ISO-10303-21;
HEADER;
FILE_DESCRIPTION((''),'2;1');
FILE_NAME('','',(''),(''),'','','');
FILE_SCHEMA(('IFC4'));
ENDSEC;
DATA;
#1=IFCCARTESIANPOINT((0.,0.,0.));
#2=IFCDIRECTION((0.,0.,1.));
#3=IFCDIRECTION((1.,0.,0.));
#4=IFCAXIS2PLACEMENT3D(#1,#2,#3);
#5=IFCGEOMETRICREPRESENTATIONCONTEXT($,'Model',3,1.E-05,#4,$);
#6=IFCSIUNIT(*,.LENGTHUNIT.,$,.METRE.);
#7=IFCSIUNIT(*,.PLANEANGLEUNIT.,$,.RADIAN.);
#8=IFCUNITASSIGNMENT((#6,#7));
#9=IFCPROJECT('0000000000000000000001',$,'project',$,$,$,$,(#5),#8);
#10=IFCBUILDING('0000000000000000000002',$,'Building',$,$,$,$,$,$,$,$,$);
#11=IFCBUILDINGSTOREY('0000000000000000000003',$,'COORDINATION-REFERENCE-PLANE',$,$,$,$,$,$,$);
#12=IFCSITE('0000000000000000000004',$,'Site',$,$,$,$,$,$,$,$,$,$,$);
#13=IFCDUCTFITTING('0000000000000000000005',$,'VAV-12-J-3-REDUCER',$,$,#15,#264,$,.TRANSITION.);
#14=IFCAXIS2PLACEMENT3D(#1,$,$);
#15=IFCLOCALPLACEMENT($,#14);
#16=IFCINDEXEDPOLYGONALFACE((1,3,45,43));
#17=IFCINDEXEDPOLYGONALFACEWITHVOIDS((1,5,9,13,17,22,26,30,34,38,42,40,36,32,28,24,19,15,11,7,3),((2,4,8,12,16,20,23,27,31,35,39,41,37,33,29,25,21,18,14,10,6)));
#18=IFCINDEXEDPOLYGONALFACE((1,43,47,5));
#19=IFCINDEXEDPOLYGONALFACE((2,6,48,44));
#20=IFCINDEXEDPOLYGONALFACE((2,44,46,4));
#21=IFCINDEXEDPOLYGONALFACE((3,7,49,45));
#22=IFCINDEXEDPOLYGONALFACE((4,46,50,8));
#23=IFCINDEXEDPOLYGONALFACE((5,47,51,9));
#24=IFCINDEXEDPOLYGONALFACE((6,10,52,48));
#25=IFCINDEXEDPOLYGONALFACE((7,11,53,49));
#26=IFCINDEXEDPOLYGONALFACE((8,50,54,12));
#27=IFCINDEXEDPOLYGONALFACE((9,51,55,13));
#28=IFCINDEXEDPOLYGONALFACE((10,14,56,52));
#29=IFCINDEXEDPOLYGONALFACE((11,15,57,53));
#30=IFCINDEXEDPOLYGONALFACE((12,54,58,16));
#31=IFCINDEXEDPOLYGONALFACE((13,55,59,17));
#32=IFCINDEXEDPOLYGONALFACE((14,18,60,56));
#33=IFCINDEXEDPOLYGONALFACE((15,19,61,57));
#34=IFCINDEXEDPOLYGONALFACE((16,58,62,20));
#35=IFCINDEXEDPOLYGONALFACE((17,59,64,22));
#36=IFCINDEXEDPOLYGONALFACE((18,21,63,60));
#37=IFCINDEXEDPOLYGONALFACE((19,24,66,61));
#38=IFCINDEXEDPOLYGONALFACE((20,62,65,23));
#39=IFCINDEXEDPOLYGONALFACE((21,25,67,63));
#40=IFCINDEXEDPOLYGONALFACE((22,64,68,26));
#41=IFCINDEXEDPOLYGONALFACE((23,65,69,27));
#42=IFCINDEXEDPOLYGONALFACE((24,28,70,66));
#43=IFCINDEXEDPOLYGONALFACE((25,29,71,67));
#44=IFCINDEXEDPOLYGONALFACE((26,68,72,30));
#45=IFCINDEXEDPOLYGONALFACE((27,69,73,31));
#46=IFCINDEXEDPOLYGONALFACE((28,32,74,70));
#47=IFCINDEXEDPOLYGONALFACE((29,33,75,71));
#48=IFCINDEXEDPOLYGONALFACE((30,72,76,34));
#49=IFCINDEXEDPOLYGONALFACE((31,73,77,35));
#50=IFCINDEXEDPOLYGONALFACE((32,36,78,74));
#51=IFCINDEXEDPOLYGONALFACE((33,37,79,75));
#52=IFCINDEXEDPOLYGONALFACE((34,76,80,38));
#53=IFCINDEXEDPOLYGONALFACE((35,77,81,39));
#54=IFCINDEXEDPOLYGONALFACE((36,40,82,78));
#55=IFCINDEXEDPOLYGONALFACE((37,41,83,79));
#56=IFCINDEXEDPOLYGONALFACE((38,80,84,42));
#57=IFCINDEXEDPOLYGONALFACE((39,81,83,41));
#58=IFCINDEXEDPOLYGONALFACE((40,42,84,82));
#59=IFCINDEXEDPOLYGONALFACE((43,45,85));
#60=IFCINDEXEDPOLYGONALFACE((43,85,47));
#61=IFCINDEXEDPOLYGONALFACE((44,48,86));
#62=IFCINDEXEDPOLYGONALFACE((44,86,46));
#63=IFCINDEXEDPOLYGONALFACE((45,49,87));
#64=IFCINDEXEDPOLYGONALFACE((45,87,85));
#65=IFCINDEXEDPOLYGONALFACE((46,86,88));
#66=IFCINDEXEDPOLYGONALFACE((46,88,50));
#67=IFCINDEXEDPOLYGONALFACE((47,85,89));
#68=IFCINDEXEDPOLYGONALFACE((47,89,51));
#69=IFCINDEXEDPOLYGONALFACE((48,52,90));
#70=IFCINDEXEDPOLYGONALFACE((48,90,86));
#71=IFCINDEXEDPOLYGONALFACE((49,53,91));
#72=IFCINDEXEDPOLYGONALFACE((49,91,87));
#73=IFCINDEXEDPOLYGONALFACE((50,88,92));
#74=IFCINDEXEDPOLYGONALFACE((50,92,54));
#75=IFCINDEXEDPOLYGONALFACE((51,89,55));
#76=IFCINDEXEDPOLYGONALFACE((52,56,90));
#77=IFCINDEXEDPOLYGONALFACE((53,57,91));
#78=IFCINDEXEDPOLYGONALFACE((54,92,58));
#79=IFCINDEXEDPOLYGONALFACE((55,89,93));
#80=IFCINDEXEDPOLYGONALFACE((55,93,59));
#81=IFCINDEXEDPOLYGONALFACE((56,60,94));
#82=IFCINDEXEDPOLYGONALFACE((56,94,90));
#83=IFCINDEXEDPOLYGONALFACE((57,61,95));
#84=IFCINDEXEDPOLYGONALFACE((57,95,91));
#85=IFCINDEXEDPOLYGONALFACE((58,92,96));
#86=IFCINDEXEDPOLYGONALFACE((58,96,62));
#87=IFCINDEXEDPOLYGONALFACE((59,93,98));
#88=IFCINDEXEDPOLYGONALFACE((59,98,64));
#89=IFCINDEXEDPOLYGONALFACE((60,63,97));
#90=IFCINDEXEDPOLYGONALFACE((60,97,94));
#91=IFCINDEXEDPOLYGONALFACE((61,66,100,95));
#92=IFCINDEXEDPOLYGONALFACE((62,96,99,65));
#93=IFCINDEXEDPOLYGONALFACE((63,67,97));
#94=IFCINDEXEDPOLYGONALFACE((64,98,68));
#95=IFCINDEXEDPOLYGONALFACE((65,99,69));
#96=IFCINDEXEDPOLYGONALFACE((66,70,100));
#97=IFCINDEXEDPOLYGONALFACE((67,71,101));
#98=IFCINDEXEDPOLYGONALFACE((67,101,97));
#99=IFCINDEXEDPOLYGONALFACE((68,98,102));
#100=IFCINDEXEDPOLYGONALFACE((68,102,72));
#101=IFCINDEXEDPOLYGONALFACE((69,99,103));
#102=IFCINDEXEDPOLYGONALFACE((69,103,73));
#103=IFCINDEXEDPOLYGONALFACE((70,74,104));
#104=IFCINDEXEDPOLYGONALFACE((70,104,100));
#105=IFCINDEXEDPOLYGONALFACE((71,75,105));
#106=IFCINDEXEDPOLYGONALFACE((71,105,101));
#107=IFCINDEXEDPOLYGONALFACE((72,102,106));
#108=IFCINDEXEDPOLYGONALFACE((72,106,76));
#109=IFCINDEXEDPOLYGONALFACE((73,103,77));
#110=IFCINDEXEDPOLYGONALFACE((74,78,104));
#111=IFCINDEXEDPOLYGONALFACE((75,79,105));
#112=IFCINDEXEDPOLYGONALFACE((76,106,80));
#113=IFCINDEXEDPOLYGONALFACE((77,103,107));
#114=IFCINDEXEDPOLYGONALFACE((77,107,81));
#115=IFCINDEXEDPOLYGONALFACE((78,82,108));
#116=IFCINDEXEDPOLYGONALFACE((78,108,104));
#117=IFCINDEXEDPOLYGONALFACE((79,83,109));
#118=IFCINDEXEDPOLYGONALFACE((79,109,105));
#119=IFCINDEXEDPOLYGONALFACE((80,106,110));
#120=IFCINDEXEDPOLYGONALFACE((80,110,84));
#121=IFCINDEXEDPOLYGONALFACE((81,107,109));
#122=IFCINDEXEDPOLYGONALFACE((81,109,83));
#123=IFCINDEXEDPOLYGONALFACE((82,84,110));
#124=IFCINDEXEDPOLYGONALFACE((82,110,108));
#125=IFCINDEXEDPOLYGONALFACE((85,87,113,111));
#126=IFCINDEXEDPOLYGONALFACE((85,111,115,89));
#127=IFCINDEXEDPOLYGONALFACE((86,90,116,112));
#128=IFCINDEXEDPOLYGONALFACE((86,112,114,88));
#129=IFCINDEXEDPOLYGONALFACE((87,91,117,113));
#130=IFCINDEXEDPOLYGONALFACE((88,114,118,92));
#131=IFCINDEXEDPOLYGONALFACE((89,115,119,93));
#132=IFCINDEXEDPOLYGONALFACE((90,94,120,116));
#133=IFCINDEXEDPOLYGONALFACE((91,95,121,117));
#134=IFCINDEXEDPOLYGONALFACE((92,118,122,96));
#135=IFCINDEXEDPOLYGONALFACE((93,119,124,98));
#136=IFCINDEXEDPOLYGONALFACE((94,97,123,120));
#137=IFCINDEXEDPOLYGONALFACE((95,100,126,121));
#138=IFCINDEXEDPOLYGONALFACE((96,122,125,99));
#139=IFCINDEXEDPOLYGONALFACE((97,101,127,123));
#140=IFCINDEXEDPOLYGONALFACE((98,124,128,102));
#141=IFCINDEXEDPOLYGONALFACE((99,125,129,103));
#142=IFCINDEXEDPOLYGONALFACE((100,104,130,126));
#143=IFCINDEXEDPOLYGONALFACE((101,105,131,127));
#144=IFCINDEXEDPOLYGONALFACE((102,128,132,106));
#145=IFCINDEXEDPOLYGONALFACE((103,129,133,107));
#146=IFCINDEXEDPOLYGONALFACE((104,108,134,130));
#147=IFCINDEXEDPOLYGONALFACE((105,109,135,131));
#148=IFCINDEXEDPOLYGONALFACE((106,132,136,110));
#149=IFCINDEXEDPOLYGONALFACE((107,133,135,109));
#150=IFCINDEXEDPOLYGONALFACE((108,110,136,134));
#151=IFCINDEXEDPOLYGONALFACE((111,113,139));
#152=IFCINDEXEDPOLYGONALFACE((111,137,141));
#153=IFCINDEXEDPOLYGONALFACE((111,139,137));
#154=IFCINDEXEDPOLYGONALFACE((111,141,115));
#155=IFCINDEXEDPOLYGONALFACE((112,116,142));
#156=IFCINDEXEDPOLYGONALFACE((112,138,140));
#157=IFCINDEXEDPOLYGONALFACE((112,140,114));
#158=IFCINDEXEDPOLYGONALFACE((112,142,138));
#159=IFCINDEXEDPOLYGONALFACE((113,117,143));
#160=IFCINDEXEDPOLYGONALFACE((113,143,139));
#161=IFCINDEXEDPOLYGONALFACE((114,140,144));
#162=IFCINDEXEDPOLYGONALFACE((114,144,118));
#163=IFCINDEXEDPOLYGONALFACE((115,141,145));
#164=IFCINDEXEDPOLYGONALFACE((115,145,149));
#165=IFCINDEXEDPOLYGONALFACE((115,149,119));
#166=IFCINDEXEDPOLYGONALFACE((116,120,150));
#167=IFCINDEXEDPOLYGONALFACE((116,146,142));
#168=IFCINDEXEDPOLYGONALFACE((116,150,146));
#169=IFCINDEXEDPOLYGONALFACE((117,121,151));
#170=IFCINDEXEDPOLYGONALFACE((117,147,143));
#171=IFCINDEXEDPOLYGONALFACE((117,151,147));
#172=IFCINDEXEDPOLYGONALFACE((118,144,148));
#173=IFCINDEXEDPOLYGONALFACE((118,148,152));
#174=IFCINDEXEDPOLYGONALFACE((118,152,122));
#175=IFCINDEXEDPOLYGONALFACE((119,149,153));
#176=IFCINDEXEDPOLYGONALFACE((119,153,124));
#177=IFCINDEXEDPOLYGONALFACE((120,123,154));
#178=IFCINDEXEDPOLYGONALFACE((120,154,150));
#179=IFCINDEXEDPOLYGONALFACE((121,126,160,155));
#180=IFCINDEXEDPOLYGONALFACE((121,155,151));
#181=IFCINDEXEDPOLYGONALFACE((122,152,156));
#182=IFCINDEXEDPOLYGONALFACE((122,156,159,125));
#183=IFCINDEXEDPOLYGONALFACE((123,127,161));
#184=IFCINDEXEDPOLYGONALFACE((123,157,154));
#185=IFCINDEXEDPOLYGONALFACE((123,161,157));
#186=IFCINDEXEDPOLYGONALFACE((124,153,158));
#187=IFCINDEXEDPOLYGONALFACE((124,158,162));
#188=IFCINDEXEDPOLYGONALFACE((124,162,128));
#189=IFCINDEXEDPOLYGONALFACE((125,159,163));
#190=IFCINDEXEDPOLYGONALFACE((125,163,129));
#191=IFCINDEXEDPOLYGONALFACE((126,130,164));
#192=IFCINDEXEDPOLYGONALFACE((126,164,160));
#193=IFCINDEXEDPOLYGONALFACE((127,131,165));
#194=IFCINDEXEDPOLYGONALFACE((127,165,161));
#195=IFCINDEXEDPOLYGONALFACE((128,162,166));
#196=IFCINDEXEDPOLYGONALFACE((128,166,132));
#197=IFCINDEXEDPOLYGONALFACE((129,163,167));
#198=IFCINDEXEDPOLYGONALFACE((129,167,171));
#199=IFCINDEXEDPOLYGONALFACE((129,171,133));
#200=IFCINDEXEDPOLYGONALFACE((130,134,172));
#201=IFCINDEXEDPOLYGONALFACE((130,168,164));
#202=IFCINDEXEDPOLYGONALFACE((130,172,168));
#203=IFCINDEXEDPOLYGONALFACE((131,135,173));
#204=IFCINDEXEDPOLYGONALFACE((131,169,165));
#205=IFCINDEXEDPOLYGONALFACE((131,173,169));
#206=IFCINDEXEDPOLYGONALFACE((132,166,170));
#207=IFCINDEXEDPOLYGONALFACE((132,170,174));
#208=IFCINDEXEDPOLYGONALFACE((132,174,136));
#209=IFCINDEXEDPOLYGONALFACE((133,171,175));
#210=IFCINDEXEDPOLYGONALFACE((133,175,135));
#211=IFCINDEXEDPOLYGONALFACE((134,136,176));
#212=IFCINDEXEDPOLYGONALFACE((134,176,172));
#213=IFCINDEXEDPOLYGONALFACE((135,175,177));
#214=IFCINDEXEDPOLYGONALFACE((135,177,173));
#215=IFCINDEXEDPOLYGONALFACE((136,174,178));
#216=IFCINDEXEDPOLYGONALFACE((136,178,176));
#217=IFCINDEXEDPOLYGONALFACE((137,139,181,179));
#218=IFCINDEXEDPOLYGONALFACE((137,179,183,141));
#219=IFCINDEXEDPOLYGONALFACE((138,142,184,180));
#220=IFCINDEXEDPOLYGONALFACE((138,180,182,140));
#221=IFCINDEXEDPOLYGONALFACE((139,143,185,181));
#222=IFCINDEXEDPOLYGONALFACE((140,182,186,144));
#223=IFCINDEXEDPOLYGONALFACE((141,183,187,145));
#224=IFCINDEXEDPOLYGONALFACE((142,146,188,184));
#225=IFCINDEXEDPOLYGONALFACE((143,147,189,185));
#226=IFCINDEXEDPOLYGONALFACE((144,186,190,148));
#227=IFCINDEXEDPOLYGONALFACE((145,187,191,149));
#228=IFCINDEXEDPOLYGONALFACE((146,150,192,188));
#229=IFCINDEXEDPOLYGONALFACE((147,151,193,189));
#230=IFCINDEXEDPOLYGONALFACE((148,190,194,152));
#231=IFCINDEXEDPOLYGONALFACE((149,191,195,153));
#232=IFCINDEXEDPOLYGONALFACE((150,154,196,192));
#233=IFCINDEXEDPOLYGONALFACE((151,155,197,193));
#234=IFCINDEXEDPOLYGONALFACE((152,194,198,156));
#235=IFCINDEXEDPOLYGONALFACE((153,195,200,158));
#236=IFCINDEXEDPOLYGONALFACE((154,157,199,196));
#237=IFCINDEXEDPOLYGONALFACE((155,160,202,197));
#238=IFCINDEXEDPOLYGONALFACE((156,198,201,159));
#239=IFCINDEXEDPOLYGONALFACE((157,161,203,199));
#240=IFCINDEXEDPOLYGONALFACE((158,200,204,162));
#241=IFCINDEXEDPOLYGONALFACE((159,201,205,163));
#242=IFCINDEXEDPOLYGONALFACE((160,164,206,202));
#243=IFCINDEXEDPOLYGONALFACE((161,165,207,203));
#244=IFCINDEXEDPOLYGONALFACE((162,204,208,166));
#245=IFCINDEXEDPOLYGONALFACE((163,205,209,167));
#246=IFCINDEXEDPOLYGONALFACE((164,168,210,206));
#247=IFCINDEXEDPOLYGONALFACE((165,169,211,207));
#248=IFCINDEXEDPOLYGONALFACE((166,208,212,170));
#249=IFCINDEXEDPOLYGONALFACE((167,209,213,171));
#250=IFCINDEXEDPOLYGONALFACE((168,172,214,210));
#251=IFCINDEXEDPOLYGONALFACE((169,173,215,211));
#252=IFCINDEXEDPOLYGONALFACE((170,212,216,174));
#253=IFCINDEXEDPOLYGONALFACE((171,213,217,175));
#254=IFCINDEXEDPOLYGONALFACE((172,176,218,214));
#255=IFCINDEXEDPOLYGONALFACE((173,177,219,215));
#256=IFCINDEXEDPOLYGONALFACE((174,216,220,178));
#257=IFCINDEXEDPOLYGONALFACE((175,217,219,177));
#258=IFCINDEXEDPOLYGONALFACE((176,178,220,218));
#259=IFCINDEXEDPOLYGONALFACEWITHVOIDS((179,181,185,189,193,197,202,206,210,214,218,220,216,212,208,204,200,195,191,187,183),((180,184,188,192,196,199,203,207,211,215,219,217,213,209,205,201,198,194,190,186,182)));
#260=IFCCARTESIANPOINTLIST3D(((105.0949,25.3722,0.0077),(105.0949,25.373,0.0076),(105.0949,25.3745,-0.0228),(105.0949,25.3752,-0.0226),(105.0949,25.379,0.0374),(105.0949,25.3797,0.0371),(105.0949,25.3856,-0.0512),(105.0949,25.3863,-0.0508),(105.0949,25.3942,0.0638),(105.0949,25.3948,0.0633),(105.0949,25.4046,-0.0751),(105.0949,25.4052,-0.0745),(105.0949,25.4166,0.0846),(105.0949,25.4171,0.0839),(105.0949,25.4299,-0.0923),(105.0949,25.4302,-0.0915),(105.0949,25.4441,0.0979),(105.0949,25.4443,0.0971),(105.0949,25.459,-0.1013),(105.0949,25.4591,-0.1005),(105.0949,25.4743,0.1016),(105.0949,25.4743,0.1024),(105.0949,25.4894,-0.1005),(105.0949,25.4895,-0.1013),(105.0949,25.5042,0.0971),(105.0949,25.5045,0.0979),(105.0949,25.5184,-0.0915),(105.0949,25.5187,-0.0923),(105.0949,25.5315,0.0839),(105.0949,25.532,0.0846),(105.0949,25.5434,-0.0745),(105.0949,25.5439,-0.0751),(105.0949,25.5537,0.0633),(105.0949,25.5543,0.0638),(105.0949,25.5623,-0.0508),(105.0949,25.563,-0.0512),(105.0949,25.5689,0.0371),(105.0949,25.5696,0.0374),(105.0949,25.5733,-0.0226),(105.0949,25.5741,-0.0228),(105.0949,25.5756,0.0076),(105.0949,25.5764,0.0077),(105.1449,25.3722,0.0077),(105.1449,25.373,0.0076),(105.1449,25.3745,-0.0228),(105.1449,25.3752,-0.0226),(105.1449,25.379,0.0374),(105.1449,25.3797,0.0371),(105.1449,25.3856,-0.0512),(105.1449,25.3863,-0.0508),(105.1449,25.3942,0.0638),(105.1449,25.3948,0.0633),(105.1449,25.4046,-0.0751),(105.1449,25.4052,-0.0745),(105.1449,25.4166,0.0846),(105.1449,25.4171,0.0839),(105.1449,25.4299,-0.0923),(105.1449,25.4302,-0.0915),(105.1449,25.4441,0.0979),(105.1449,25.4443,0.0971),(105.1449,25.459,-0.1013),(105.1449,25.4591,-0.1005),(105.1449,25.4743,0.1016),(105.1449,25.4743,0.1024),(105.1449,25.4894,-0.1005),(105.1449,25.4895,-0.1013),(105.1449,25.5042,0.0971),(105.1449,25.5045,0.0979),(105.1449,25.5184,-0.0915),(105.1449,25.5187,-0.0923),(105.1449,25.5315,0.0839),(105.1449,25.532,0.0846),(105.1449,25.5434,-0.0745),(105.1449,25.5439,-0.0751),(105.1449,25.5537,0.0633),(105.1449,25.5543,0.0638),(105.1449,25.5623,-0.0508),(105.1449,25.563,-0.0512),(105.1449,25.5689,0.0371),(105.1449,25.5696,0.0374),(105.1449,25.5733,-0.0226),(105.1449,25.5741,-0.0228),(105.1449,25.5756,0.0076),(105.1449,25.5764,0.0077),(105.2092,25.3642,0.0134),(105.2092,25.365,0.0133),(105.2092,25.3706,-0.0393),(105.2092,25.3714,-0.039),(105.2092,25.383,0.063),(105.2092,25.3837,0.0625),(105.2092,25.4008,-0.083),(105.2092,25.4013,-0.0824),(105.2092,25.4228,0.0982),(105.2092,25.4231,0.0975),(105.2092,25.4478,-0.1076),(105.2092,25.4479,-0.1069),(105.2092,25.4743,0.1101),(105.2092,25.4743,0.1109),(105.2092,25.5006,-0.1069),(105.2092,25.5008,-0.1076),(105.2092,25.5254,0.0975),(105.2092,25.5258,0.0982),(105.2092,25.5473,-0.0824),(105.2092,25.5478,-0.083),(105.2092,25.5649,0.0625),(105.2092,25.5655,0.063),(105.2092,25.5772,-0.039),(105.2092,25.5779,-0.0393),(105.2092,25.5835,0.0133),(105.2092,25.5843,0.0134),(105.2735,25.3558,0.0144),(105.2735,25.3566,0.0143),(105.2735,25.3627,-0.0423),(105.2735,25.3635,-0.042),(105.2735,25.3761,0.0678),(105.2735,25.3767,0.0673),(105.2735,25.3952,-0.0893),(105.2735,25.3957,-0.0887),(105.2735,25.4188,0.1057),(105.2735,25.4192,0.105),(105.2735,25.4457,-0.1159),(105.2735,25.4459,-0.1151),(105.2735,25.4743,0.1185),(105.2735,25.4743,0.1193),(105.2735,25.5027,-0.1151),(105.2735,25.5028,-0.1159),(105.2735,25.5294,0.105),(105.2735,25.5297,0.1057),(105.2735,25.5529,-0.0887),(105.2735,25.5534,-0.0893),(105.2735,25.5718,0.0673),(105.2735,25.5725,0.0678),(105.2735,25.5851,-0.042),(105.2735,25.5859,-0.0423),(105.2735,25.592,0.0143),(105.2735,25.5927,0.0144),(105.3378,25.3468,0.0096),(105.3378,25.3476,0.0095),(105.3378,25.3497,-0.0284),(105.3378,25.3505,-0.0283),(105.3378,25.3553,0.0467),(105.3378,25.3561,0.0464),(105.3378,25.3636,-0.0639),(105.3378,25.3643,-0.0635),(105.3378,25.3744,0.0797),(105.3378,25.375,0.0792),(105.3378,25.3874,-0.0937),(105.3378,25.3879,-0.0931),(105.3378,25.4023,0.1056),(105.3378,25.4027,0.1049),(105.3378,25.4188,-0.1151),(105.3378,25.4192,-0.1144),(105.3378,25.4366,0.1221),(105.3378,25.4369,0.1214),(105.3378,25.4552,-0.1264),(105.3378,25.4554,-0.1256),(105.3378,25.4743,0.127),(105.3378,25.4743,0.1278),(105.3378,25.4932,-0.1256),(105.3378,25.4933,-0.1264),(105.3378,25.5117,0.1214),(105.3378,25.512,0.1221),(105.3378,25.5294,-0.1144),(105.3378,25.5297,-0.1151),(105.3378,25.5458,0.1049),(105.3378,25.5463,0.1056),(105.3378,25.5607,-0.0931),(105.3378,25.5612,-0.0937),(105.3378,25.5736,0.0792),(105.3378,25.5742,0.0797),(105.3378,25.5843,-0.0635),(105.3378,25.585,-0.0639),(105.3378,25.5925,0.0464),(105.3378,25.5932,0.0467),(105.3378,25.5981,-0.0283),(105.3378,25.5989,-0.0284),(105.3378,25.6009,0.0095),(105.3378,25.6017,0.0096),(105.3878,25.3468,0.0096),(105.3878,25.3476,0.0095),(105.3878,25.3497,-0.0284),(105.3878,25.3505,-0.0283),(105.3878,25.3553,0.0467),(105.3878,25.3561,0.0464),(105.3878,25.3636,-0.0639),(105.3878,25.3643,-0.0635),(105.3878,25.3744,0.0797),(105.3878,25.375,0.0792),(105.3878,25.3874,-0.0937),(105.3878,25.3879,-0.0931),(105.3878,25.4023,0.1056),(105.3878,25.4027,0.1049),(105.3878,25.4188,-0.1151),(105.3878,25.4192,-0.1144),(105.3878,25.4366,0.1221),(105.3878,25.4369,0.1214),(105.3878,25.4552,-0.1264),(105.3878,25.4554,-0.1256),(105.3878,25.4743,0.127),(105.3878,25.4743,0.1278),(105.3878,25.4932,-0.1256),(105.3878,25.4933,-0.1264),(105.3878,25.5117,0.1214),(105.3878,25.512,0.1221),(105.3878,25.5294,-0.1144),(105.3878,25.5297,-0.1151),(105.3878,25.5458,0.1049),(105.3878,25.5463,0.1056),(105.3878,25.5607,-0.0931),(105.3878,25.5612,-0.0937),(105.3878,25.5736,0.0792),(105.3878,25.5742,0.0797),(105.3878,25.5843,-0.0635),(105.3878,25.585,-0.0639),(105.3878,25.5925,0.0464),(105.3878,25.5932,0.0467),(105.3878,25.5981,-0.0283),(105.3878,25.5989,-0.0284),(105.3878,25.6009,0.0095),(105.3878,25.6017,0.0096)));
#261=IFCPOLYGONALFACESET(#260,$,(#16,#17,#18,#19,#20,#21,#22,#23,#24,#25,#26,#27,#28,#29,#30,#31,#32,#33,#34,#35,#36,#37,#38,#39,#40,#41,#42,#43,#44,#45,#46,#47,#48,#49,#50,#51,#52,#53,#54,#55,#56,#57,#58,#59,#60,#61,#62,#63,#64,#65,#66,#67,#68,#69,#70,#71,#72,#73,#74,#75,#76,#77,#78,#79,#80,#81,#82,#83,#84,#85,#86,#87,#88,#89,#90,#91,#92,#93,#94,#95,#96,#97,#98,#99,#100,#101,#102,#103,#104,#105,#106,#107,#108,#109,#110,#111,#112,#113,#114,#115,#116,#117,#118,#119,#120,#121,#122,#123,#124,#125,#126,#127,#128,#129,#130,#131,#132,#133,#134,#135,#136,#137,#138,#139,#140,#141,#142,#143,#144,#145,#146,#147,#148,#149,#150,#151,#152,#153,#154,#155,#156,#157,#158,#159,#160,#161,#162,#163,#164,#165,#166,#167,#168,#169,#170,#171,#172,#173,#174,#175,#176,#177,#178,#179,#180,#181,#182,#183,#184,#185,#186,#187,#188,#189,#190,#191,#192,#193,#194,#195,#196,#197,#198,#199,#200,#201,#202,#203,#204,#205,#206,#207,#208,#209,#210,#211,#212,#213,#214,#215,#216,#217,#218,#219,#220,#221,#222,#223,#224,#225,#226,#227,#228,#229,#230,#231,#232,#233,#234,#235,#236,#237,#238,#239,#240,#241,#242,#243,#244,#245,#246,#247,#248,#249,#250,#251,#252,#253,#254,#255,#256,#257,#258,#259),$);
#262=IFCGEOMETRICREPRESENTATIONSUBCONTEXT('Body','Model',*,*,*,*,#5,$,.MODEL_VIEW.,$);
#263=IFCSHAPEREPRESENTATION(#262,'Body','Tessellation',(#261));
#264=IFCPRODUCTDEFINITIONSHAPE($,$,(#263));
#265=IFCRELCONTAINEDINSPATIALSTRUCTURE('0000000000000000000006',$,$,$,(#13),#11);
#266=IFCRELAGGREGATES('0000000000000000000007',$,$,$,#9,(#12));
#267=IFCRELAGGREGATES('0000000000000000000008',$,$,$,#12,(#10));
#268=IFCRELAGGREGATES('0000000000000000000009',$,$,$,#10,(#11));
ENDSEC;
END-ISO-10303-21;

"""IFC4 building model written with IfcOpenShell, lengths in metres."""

from ifc_helpers import new_model, entity, si_unit, frame, origin_with_axes, place, context, subcontext, project, spatial, element, save


model = new_model("IFC4")

# Units and contexts
model_context = context("Model", 3, precision=1e-05, world=origin_with_axes())
body_context_1 = subcontext(model_context, "Body", "Model", "MODEL_VIEW")
ifc_project = project(units=[si_unit("LENGTHUNIT", "METRE"), si_unit("PLANEANGLEUNIT", "RADIAN")], contexts=[model_context])

# Site, building, storey
site = spatial("IfcSite", under=ifc_project, Name="Site")
building = spatial("IfcBuilding", under=site, Name="Building")
storey = spatial("IfcBuildingStorey", under=building, Name="COORDINATION-REFERENCE-PLANE")

# Duct fitting
for number, where, z_axis, x_axis, name in (
    (1, (105.3878, 25.4743, 0.0), (0.0, -1.0, 0.0), (0.0, 0.0, 1.0), "VAV-12-J-3-REDUCER"),
):
    element("IfcDuctFitting", number, at=place(None, frame(where, z_axis=z_axis, x_axis=x_axis)), inside=storey, Name=name, PredefinedType="TRANSITION", context=body_context_1, shape_type="SweptSolid", body=[
        entity("IfcRevolvedAreaSolid", entity("IfcArbitraryClosedProfileDef", "AREA", None, entity("IfcPolyline", [entity("IfcCartesianPoint", [0.1278, 0.0]), entity("IfcCartesianPoint", [0.1278, 0.05]), entity("IfcCartesianPoint", [0.1024, 0.2429]), entity("IfcCartesianPoint", [0.1024, 0.2929]), entity("IfcCartesianPoint", [0.1016, 0.2929]), entity("IfcCartesianPoint", [0.1016, 0.2429]), entity("IfcCartesianPoint", [0.127, 0.05]), entity("IfcCartesianPoint", [0.127, 0.0]), entity("IfcCartesianPoint", [0.1278, 0.0])])), entity("IfcAxis2Placement3D", entity("IfcCartesianPoint", [0.0, 0.0, 0.0])), entity("IfcAxis1Placement", entity("IfcCartesianPoint", [0.0, 0.0, 0.0]), entity("IfcDirection", [0.0, 1.0, 0.0])), 6.283185),
    ])

save(model, "model.ifc")
